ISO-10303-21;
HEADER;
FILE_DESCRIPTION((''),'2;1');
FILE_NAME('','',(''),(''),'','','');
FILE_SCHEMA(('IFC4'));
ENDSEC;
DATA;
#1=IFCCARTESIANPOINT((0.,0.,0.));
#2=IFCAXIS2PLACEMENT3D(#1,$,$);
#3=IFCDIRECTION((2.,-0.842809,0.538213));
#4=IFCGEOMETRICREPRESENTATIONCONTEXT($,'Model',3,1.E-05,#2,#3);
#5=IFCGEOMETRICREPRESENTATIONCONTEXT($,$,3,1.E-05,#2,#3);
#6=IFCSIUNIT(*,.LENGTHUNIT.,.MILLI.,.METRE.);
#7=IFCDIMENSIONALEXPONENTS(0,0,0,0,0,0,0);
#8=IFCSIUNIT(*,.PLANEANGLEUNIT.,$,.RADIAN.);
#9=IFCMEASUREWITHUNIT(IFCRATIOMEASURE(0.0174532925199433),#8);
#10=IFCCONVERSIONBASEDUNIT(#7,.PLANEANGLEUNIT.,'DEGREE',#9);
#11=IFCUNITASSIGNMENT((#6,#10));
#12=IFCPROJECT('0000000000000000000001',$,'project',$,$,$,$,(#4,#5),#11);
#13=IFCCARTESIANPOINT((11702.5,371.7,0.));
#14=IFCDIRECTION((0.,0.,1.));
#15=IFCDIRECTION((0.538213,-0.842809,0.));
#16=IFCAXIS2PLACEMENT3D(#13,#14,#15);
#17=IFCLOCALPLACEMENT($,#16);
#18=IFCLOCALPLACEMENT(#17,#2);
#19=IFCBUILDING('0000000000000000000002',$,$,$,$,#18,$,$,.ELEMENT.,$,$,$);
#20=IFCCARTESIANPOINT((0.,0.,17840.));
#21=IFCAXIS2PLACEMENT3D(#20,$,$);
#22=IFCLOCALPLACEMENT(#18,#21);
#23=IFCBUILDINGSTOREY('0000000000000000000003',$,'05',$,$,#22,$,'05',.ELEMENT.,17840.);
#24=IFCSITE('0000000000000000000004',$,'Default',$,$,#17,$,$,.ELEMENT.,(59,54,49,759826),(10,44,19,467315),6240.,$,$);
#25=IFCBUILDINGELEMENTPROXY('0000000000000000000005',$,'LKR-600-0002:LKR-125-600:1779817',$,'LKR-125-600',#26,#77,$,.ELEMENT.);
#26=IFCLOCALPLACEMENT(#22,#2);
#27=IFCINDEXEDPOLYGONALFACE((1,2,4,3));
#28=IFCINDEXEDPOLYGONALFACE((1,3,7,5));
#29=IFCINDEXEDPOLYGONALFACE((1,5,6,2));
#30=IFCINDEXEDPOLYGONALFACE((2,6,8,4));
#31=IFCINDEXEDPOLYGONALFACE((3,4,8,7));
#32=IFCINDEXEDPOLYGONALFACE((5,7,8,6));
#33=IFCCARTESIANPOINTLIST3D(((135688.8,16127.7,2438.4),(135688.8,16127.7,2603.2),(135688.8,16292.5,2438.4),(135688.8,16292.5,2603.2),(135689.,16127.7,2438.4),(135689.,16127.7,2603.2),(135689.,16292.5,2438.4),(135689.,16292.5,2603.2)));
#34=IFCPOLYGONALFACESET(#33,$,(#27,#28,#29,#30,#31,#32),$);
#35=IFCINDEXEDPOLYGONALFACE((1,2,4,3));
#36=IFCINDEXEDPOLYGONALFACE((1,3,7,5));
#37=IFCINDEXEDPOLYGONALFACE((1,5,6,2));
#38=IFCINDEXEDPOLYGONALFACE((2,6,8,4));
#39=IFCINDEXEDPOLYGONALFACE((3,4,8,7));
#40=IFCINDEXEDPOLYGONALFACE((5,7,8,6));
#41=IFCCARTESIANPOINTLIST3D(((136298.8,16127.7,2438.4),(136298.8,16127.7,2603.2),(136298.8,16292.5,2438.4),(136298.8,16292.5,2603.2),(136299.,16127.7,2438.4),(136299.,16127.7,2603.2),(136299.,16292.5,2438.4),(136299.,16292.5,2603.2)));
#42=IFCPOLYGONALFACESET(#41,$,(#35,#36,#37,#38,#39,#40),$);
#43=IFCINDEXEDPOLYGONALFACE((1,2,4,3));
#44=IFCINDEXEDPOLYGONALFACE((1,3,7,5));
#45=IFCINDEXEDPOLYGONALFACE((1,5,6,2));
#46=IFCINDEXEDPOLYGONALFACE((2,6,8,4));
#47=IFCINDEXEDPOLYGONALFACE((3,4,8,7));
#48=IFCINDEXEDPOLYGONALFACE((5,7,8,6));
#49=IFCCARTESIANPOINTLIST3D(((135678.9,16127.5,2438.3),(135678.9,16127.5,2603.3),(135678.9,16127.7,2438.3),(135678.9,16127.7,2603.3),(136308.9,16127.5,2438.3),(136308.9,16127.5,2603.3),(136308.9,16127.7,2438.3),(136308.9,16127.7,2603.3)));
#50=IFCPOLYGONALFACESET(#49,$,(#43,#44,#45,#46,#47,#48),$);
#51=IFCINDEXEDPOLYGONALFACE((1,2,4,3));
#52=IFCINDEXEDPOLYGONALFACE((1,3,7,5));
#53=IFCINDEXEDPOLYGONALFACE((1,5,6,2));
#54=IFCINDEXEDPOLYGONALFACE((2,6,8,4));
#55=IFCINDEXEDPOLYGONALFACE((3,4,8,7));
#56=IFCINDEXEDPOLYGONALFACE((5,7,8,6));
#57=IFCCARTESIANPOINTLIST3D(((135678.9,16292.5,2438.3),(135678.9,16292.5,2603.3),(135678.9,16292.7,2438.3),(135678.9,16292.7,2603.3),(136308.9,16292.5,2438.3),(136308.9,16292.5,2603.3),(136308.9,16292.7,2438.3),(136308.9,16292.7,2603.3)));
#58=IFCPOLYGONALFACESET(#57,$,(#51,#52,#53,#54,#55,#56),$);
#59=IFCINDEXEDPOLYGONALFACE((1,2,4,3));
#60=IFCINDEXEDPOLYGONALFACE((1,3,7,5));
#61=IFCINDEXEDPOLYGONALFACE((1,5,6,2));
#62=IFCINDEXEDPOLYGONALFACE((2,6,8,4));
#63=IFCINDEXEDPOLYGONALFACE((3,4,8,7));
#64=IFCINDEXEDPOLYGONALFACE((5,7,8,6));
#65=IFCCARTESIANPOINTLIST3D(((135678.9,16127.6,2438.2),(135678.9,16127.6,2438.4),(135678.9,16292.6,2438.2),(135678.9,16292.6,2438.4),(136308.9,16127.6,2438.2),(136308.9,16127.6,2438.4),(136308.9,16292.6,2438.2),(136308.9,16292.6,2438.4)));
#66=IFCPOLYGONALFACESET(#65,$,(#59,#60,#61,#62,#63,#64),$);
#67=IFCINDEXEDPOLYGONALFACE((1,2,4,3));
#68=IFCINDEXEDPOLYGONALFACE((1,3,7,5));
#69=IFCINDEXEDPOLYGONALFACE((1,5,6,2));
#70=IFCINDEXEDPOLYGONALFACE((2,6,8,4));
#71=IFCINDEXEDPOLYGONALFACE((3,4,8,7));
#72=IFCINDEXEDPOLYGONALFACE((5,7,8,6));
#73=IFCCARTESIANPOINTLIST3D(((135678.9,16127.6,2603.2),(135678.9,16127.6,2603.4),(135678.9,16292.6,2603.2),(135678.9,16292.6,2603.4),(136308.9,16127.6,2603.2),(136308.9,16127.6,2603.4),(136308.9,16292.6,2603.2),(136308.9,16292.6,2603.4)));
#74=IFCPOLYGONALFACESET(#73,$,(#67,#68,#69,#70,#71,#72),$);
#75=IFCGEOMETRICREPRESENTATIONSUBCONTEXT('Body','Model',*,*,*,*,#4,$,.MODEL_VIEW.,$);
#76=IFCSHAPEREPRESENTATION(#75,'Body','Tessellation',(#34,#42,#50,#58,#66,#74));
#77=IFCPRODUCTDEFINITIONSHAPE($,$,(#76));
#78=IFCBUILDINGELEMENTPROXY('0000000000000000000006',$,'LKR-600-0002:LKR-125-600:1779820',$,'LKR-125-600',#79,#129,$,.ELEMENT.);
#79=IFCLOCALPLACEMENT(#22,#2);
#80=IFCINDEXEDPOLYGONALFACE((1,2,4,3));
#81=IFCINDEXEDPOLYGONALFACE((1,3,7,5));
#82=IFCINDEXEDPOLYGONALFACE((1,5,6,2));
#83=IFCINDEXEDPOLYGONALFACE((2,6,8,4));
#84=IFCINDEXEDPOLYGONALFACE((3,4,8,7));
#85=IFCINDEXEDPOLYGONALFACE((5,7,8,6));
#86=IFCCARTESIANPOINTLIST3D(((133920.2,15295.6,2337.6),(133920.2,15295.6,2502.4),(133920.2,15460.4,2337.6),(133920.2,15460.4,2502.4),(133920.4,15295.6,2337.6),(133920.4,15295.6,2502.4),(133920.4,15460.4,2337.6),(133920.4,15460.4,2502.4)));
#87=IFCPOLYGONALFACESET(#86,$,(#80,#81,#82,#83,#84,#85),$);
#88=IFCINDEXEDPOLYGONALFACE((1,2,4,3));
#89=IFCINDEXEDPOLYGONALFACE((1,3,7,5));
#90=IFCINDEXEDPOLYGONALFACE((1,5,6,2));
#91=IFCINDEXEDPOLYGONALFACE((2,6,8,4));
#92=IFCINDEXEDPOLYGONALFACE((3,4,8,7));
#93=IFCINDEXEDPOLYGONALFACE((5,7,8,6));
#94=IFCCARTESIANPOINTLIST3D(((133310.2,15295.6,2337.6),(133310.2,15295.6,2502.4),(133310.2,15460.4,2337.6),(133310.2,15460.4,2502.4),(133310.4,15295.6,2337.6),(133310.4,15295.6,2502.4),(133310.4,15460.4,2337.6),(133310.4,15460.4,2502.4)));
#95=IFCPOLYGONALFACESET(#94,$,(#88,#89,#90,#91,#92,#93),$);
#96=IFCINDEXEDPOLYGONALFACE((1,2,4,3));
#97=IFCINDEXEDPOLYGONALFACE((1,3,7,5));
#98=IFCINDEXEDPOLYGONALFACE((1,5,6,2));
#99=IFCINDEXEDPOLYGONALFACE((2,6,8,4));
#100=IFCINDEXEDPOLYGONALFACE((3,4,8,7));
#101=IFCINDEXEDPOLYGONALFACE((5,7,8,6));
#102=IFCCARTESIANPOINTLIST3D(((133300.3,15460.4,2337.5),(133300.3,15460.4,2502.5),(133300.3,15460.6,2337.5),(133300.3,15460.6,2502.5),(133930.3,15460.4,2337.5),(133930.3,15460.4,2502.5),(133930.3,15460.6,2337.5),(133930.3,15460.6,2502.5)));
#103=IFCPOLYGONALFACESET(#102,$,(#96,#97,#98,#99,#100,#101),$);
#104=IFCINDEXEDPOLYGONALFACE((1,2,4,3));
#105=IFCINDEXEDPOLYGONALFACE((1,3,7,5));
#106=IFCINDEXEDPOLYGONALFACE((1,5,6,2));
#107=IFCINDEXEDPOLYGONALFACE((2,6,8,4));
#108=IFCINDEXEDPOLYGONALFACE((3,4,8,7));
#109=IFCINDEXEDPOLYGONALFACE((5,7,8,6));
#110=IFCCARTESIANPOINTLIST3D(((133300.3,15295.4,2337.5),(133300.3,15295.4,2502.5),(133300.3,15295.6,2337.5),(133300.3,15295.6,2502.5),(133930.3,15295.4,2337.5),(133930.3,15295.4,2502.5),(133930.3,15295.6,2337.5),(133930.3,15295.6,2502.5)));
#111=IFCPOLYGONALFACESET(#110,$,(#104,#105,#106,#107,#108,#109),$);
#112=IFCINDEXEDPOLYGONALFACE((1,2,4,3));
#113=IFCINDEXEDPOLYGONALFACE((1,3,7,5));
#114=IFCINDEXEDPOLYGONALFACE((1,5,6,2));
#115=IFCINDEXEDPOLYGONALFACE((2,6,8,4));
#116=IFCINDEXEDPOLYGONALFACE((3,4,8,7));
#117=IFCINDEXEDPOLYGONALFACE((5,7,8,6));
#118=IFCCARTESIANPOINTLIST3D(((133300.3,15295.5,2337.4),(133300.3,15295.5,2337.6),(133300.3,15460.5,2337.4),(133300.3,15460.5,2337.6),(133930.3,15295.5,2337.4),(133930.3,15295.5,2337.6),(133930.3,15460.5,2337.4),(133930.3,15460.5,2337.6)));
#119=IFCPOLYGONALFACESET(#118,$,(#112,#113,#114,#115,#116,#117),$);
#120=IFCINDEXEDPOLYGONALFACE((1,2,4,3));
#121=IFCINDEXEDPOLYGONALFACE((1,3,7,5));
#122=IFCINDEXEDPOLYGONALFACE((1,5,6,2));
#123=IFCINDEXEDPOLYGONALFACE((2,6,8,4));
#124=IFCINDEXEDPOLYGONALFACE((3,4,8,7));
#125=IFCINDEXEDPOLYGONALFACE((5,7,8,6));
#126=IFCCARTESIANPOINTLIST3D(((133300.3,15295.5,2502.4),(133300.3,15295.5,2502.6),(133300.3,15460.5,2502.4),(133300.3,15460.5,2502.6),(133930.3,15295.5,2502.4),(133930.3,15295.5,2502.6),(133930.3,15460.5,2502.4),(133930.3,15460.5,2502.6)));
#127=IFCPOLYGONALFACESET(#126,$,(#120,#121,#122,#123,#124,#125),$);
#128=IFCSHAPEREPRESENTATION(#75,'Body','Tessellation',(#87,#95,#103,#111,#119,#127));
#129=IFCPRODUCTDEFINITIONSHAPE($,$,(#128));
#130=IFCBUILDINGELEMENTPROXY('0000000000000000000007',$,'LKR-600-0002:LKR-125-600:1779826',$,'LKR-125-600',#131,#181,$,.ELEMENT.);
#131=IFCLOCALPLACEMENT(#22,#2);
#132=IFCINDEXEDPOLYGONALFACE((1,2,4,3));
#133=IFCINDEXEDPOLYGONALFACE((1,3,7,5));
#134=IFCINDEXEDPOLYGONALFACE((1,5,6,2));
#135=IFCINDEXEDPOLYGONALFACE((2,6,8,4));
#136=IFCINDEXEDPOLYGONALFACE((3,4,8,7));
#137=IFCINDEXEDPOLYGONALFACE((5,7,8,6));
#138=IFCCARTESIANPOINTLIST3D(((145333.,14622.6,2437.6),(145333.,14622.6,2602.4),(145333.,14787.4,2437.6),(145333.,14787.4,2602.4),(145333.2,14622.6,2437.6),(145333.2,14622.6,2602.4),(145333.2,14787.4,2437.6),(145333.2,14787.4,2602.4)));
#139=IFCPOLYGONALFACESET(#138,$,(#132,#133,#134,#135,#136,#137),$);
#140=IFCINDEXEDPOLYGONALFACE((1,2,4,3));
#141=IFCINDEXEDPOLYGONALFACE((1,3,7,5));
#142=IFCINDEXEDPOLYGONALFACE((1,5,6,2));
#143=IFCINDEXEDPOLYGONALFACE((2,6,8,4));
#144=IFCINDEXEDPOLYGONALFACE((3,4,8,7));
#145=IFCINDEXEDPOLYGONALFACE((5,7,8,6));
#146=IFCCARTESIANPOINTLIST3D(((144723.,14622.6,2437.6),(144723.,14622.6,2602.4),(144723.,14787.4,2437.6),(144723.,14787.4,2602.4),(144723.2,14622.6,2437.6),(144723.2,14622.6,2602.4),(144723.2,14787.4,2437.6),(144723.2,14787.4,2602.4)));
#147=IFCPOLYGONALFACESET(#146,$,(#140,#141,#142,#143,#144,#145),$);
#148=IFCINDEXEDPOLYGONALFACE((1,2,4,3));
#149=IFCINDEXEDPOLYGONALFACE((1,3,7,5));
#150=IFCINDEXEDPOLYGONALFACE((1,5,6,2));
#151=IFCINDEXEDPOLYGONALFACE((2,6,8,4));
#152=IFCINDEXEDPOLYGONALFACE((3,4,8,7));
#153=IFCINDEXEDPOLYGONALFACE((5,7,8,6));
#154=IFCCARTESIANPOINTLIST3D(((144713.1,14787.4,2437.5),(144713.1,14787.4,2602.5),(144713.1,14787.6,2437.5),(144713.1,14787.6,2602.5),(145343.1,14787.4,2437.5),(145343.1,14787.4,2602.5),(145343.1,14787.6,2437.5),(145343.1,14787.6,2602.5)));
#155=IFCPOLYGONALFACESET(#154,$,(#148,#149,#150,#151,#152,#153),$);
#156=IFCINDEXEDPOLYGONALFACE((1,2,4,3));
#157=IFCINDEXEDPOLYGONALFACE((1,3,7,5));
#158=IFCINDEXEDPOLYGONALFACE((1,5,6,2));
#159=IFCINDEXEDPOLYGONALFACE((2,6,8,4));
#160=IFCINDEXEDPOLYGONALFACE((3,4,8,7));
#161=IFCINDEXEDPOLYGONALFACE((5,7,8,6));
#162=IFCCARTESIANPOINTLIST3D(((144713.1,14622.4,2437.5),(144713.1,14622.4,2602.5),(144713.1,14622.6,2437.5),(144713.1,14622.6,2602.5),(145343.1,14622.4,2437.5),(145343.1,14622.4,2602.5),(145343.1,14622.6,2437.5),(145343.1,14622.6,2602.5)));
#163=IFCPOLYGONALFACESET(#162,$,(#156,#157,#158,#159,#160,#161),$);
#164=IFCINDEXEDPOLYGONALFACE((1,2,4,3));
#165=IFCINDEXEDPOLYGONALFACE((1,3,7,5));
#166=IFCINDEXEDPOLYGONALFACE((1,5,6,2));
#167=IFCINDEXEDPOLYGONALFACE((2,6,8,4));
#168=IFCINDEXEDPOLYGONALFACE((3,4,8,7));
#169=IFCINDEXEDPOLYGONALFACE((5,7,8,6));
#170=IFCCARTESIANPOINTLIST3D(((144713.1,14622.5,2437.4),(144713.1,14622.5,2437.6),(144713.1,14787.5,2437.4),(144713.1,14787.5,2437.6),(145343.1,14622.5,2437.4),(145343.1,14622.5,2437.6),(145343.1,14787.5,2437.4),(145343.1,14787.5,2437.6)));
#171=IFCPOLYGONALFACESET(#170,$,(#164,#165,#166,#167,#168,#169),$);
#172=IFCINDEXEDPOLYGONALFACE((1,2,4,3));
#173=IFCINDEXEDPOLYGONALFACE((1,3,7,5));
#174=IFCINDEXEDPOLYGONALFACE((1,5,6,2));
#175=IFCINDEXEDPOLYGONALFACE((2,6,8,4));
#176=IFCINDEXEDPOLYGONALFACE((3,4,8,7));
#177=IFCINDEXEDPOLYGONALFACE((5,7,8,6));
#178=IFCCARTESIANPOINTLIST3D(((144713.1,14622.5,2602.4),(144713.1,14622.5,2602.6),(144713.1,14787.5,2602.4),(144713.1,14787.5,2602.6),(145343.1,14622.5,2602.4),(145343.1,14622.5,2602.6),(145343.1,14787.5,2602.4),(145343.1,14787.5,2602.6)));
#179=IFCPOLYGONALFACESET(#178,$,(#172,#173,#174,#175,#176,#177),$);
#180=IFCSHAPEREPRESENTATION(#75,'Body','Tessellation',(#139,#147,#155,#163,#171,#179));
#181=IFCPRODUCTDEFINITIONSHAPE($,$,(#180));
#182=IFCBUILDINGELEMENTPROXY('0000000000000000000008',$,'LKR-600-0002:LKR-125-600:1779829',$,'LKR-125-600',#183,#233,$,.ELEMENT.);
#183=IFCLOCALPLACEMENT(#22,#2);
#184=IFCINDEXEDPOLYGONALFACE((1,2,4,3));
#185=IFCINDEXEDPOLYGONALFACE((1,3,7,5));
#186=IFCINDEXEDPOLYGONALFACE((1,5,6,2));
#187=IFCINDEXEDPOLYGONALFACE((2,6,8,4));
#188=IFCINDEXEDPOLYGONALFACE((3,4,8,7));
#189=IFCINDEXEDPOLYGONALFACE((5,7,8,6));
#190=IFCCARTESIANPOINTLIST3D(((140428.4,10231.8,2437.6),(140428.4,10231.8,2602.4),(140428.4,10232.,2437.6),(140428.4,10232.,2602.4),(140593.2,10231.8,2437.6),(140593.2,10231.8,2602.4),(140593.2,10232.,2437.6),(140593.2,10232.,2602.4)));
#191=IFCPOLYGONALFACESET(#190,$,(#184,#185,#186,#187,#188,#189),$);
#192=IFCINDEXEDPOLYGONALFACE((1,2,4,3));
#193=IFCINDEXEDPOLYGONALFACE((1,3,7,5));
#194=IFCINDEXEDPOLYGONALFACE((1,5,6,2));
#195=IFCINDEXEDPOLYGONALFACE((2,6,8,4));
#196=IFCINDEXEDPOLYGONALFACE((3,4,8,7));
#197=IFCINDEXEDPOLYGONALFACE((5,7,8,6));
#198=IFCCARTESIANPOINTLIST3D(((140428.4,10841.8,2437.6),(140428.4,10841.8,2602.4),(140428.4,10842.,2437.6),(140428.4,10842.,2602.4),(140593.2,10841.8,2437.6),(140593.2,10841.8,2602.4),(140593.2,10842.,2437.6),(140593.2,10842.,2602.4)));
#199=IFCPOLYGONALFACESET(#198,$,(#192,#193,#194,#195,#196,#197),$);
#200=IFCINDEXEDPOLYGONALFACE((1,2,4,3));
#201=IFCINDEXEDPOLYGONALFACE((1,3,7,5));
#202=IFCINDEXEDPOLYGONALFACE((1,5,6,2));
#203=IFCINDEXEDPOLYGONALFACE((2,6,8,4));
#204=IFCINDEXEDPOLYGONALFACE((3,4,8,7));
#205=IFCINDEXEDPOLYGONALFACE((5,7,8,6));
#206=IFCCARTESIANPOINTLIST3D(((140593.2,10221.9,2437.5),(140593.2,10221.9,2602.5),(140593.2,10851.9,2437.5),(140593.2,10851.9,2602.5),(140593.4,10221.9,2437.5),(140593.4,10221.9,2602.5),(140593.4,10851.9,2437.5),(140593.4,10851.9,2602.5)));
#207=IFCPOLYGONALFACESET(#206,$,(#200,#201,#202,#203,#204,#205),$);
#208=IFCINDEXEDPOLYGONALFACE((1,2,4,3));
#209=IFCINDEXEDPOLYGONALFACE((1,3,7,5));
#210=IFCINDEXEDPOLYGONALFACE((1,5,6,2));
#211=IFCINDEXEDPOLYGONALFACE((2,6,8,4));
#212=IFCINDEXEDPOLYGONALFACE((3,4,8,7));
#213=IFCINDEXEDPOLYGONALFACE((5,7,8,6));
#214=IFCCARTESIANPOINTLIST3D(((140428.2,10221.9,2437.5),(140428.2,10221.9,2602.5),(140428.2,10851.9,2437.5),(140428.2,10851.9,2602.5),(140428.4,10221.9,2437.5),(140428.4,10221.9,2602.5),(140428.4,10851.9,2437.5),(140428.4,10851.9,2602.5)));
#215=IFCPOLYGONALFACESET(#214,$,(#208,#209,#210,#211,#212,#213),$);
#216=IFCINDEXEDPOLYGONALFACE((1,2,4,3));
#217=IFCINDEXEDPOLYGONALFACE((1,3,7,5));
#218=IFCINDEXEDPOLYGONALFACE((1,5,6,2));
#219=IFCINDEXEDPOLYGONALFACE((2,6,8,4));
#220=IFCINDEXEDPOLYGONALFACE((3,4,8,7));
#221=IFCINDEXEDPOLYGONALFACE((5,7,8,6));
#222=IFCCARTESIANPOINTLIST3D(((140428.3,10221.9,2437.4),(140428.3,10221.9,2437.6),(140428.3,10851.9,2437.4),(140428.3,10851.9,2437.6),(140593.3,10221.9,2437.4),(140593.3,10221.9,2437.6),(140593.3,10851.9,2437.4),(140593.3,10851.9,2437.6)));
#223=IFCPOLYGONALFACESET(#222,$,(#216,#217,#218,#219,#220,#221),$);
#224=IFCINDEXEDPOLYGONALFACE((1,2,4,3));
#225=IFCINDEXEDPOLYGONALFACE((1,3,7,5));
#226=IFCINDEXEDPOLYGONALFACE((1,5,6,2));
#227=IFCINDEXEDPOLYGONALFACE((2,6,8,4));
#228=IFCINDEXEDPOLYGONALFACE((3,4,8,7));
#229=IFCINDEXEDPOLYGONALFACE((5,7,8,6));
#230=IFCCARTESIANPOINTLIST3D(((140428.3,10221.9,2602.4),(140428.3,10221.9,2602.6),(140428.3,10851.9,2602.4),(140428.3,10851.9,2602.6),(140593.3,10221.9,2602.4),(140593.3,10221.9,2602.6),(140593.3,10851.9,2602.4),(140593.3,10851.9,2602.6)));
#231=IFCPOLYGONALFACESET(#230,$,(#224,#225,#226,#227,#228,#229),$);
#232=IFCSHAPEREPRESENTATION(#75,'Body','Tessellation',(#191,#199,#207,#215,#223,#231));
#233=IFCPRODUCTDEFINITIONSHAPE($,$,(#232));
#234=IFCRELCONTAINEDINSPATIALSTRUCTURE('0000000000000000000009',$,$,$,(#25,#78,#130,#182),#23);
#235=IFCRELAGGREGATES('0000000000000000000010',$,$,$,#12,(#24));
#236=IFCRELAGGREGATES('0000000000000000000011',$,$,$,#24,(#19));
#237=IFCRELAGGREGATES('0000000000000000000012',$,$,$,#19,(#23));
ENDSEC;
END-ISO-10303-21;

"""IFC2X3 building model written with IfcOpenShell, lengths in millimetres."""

from ifc_helpers import new_model, entity, si_unit, converted_unit, direction, frame, frame_2d, origin, place, context, subcontext, project, spatial, rectangle, extrude, source, transform, mapped, element, save


model = new_model("IFC2X3")

# Units and contexts
model_context = context("Model", 3, precision=1e-05, world=origin(), true_north=direction((2.0, -0.842809, 0.538213)))
context_of_model = context(None, 3, precision=1e-05, world=origin(), true_north=direction((2.0, -0.842809, 0.538213)))
body_context = subcontext(model_context, "Body", "Model", "MODEL_VIEW")
ifc_project = project(units=[si_unit("LENGTHUNIT", "METRE", prefix="MILLI"), converted_unit("PLANEANGLEUNIT", "DEGREE", entity("IfcRatioMeasure", 0.0174532925199433), si_unit("PLANEANGLEUNIT", "RADIAN"), dimensions=[0, 0, 0, 0, 0, 0, 0])], contexts=[model_context, context_of_model])

# Site, building, storey
site_placement = place(None, frame((11702.5, 371.7, 0.0), z_axis=(0.0, 0.0, 1.0), x_axis=(0.538213, -0.842809, 0.0)))
site = spatial("IfcSite", under=ifc_project, at=site_placement, Name="Default", CompositionType="ELEMENT", RefLatitude=(59, 54, 49, 759826), RefLongitude=(10, 44, 19, 467315), RefElevation=6240.0)
building_placement = place(site_placement, origin())
building = spatial("IfcBuilding", under=site, at=building_placement, CompositionType="ELEMENT")
storey_placement = place(building_placement, frame((0.0, 0.0, 17840.0)))
storey = spatial("IfcBuildingStorey", under=building, at=storey_placement, Name="05", LongName="05", CompositionType="ELEMENT", Elevation=17840.0)

# Building element proxies
shared_shape_1 = source(origin(), body_context, "Body", "SweptSolid", [
    extrude(rectangle(XDim=0.2, YDim=164.8, at=frame_2d((0.0, 0.0), x_axis=(1.0, 0.0))), frame((305.0, 0.0, -82.4)), (0.0, 0.0, 1.0), 164.8),
    extrude(rectangle(XDim=0.2, YDim=164.8, at=frame_2d((0.0, 0.0), x_axis=(1.0, 0.0))), frame((-305.0, 0.0, -82.4)), (0.0, 0.0, 1.0), 164.8),
    extrude(rectangle(XDim=0.2, YDim=630.0, at=frame_2d((0.0, 0.0), x_axis=(1.0, 0.0))), frame((0.0, 82.5, -82.5), z_axis=(0.0, 0.0, 1.0), x_axis=(0.0, 1.0, 0.0)), (0.0, 0.0, 1.0), 165.0),
    extrude(rectangle(XDim=0.2, YDim=630.0, at=frame_2d((0.0, 0.0), x_axis=(1.0, 0.0))), frame((0.0, -82.5, -82.5), z_axis=(0.0, 0.0, 1.0), x_axis=(0.0, 1.0, 0.0)), (0.0, 0.0, 1.0), 165.0),
    extrude(rectangle(XDim=165.0, YDim=630.0, at=frame_2d((0.0, 0.0), x_axis=(1.0, 0.0))), frame((0.0, 0.0, -82.6), z_axis=(0.0, 0.0, 1.0), x_axis=(0.0, -1.0, 0.0)), (0.0, 0.0, 1.0), 0.2),
    extrude(rectangle(XDim=165.0, YDim=630.0, at=frame_2d((0.0, 0.0), x_axis=(1.0, 0.0))), frame((0.0, 0.0, 82.4), z_axis=(0.0, 0.0, 1.0), x_axis=(0.0, -1.0, 0.0)), (0.0, 0.0, 1.0), 0.2),
])
proxy_placement = place(storey_placement, frame((135993.9, 16210.1, 2520.8), z_axis=(0.0, 0.0, 1.0), x_axis=(-1.0, 0.0, 0.0)))
element("IfcBuildingElementProxy", 1, at=proxy_placement, inside=storey, Name="LKR-600-0002:LKR-125-600:1779817", ObjectType="LKR-125-600", CompositionType="ELEMENT", context=body_context, shape_type="MappedRepresentation", body=[
    mapped(shared_shape_1, transform((0.0, 0.0, 0.0), scale=1.0)),
])
for number, where, name in (
    (2, (133615.3, 15378.0, 2420.0), "LKR-600-0002:LKR-125-600:1779820"),
    (3, (145028.1, 14705.0, 2520.0), "LKR-600-0002:LKR-125-600:1779826"),
):
    element("IfcBuildingElementProxy", number, at=place(storey_placement, frame(where)), inside=storey, Name=name, ObjectType="LKR-125-600", CompositionType="ELEMENT", context=body_context, shape_type="MappedRepresentation", body=[
        mapped(shared_shape_1, transform((0.0, 0.0, 0.0), scale=1.0)),
    ])
for number, where, z_axis, x_axis, name in (
    (4, (140510.8, 10536.9, 2520.0), (0.0, 0.0, 1.0), (0.0, -1.0, 0.0), "LKR-600-0002:LKR-125-600:1779829"),
):
    element("IfcBuildingElementProxy", number, at=place(storey_placement, frame(where, z_axis=z_axis, x_axis=x_axis)), inside=storey, Name=name, ObjectType="LKR-125-600", CompositionType="ELEMENT", context=body_context, shape_type="MappedRepresentation", body=[
        mapped(shared_shape_1, transform((0.0, 0.0, 0.0), scale=1.0)),
    ])

save(model, "model.ifc")
